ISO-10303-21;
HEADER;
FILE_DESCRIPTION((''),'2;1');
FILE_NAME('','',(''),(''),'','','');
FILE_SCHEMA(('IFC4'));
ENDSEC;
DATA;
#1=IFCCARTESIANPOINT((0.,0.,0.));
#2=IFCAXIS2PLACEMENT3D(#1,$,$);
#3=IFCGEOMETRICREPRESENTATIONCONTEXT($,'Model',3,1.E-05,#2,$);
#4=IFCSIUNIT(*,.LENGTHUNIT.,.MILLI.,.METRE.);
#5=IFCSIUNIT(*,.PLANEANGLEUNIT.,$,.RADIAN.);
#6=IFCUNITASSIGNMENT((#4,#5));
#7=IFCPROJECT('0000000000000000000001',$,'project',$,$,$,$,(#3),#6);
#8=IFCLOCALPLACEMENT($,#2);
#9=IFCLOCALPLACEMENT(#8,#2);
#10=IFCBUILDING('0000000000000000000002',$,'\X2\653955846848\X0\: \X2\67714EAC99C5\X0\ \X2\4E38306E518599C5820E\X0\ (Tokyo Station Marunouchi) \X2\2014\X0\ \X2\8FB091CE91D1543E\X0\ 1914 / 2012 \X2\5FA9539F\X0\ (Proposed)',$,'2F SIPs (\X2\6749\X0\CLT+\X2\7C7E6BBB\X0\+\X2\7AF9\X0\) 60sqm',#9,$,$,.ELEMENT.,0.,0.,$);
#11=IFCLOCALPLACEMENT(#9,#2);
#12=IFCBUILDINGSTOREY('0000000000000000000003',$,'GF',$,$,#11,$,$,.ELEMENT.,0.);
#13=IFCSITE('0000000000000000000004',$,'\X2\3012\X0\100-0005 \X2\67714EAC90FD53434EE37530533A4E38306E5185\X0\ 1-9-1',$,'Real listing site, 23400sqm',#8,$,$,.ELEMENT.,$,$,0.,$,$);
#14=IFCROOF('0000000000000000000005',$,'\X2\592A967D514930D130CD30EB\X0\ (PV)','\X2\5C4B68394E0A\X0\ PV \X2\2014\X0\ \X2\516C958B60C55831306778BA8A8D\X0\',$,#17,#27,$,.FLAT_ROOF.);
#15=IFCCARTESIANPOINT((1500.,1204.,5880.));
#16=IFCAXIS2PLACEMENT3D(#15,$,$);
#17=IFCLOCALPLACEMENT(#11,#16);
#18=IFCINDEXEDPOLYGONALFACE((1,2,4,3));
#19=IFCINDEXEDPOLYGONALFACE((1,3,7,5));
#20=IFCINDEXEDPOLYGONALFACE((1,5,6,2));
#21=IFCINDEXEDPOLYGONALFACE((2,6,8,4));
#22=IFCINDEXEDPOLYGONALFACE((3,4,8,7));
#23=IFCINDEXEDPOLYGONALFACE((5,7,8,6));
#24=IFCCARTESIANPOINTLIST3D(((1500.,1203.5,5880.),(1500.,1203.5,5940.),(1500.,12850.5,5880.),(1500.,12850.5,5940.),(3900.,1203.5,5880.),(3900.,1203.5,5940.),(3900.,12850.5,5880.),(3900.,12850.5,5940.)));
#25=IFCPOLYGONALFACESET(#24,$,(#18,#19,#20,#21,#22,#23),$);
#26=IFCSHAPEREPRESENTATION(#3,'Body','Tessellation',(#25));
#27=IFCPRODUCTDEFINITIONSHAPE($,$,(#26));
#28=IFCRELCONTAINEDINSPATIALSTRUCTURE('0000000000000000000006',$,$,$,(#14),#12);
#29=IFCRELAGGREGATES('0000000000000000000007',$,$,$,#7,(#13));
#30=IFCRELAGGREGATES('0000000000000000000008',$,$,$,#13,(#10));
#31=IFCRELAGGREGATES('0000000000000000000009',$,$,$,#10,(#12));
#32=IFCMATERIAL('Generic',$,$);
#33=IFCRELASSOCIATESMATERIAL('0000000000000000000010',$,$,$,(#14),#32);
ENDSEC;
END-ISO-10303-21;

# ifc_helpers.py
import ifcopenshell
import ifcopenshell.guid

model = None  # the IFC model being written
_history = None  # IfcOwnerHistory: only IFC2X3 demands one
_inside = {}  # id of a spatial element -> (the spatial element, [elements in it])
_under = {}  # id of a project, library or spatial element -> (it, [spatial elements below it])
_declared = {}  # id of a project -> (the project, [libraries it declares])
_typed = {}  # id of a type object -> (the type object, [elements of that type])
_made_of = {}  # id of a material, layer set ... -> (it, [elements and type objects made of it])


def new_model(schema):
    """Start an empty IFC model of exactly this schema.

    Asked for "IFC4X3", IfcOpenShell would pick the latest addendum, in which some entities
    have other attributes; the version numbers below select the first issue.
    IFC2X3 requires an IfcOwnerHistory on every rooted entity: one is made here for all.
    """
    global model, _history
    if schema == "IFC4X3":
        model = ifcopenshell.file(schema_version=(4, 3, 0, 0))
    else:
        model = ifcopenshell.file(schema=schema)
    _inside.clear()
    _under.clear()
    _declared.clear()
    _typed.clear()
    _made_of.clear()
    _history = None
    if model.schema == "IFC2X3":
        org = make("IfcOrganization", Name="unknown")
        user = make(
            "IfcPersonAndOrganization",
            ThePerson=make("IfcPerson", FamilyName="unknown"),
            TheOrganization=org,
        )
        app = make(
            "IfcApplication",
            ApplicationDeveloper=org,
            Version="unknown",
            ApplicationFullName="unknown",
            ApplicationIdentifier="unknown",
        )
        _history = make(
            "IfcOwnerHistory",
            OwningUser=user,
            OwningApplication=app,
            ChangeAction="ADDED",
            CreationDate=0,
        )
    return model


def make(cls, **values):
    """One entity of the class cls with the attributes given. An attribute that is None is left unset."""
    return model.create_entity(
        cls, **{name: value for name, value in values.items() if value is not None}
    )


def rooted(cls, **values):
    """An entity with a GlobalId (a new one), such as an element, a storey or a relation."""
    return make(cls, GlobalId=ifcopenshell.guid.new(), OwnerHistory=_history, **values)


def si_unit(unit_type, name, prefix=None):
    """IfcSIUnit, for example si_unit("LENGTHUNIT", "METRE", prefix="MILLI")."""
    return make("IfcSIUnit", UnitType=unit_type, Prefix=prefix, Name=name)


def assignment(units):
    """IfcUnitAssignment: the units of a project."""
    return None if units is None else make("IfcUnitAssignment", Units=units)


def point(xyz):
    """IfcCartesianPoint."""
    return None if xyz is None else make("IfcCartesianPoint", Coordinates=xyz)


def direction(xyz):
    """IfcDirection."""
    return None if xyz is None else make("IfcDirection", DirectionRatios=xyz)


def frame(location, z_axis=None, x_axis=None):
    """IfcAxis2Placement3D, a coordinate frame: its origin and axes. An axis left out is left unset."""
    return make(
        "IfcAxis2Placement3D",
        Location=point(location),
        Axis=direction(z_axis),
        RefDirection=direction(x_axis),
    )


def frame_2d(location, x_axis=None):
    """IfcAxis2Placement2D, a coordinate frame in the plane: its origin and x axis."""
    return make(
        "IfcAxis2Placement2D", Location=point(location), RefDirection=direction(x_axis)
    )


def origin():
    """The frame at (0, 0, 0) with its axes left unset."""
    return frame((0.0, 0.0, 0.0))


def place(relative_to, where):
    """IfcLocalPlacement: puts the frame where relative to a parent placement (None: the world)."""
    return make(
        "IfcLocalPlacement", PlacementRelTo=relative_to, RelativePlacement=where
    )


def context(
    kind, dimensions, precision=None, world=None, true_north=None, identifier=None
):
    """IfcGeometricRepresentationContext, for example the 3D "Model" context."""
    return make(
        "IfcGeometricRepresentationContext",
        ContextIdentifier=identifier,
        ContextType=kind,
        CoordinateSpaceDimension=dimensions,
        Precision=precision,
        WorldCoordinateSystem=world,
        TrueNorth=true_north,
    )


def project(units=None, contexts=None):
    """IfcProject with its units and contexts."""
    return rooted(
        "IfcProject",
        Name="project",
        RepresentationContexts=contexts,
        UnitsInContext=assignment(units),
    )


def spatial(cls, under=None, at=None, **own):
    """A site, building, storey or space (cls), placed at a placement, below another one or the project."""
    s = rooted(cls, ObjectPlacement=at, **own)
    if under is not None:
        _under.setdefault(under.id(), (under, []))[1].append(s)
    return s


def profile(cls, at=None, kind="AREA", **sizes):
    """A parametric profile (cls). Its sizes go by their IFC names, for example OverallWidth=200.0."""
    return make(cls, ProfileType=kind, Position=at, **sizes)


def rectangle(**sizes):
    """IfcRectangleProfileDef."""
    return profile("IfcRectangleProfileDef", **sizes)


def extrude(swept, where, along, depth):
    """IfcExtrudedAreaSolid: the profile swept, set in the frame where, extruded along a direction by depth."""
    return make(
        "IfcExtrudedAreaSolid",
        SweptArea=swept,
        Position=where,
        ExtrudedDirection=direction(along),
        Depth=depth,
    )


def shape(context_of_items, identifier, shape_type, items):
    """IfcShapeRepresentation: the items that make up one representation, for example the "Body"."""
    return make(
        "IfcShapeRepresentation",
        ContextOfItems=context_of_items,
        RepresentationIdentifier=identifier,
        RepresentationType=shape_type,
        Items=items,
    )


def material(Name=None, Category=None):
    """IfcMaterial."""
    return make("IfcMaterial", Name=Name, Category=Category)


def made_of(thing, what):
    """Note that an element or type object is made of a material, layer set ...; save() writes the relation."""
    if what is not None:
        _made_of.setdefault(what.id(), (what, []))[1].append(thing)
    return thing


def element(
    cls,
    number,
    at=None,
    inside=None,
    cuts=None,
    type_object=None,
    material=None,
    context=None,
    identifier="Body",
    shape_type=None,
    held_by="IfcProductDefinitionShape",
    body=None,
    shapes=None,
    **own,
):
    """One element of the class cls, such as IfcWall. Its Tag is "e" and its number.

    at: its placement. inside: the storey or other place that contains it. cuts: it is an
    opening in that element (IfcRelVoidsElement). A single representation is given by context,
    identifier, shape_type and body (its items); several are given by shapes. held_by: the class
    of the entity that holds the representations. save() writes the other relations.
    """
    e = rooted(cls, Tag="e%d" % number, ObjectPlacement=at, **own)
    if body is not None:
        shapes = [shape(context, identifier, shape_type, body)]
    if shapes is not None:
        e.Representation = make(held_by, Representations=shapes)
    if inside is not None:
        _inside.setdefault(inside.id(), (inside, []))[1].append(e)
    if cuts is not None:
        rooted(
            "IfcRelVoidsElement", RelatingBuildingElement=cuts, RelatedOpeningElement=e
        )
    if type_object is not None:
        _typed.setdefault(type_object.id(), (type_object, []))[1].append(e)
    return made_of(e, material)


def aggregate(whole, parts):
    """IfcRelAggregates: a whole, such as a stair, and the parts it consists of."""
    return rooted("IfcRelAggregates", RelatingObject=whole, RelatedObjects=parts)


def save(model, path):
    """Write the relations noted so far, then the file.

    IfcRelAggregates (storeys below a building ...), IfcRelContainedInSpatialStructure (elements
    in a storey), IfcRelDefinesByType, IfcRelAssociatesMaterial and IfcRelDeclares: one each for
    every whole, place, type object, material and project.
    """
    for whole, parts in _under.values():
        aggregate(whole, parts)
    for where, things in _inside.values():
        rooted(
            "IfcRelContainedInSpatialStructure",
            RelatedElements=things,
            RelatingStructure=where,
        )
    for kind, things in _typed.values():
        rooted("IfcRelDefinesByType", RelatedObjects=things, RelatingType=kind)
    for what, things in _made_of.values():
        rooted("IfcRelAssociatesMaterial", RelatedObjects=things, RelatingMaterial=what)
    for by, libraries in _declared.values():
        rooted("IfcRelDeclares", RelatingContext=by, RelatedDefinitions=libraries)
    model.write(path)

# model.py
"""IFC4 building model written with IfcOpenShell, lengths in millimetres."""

from ifc_helpers import new_model, si_unit, frame, frame_2d, origin, place, context, project, spatial, rectangle, extrude, material, element, save


model = new_model("IFC4")

# Units and contexts
model_context = context("Model", 3, precision=1e-05, world=origin())
ifc_project = project(units=[si_unit("LENGTHUNIT", "METRE", prefix="MILLI"), si_unit("PLANEANGLEUNIT", "RADIAN")], contexts=[model_context])

# Site, building, storey
site_placement = place(None, origin())
site = spatial("IfcSite", under=ifc_project, at=site_placement, Name="〒100-0005 東京都千代田区丸の内 1-9-1", ObjectType="Real listing site, 23400sqm", CompositionType="ELEMENT", RefElevation=0.0)
building_placement = place(site_placement, origin())
building = spatial("IfcBuilding", under=site, at=building_placement, Name="改善案: 東京駅 丸の内駅舎 (Tokyo Station Marunouchi) — 辰野金吾 1914 / 2012 復原 (Proposed)", ObjectType="2F SIPs (杉CLT+籾殻+竹) 60sqm", CompositionType="ELEMENT", ElevationOfRefHeight=0.0, ElevationOfTerrain=0.0)
storey_placement = place(building_placement, origin())
storey = spatial("IfcBuildingStorey", under=building, at=storey_placement, Name="GF", CompositionType="ELEMENT", Elevation=0.0)

# Shared definitions
ifc_material_1 = material(Name="Generic")

# Roof
roof_placement = place(storey_placement, frame((1500.0, 1204.0, 5880.0)))
element("IfcRoof", 1, at=roof_placement, inside=storey, material=ifc_material_1, Name="太陽光パネル (PV)", Description="屋根上 PV — 公開情報で確認", PredefinedType="FLAT_ROOF", context=model_context, shape_type="SweptSolid", body=[
    extrude(rectangle(XDim=2400.0, YDim=11647.0, at=frame_2d((1200.0, 5823.0))), frame((1500.0, 1204.0, 5880.0)), (0.0, 0.0, 1.0), 60.0),
])

save(model, "model.ifc")
